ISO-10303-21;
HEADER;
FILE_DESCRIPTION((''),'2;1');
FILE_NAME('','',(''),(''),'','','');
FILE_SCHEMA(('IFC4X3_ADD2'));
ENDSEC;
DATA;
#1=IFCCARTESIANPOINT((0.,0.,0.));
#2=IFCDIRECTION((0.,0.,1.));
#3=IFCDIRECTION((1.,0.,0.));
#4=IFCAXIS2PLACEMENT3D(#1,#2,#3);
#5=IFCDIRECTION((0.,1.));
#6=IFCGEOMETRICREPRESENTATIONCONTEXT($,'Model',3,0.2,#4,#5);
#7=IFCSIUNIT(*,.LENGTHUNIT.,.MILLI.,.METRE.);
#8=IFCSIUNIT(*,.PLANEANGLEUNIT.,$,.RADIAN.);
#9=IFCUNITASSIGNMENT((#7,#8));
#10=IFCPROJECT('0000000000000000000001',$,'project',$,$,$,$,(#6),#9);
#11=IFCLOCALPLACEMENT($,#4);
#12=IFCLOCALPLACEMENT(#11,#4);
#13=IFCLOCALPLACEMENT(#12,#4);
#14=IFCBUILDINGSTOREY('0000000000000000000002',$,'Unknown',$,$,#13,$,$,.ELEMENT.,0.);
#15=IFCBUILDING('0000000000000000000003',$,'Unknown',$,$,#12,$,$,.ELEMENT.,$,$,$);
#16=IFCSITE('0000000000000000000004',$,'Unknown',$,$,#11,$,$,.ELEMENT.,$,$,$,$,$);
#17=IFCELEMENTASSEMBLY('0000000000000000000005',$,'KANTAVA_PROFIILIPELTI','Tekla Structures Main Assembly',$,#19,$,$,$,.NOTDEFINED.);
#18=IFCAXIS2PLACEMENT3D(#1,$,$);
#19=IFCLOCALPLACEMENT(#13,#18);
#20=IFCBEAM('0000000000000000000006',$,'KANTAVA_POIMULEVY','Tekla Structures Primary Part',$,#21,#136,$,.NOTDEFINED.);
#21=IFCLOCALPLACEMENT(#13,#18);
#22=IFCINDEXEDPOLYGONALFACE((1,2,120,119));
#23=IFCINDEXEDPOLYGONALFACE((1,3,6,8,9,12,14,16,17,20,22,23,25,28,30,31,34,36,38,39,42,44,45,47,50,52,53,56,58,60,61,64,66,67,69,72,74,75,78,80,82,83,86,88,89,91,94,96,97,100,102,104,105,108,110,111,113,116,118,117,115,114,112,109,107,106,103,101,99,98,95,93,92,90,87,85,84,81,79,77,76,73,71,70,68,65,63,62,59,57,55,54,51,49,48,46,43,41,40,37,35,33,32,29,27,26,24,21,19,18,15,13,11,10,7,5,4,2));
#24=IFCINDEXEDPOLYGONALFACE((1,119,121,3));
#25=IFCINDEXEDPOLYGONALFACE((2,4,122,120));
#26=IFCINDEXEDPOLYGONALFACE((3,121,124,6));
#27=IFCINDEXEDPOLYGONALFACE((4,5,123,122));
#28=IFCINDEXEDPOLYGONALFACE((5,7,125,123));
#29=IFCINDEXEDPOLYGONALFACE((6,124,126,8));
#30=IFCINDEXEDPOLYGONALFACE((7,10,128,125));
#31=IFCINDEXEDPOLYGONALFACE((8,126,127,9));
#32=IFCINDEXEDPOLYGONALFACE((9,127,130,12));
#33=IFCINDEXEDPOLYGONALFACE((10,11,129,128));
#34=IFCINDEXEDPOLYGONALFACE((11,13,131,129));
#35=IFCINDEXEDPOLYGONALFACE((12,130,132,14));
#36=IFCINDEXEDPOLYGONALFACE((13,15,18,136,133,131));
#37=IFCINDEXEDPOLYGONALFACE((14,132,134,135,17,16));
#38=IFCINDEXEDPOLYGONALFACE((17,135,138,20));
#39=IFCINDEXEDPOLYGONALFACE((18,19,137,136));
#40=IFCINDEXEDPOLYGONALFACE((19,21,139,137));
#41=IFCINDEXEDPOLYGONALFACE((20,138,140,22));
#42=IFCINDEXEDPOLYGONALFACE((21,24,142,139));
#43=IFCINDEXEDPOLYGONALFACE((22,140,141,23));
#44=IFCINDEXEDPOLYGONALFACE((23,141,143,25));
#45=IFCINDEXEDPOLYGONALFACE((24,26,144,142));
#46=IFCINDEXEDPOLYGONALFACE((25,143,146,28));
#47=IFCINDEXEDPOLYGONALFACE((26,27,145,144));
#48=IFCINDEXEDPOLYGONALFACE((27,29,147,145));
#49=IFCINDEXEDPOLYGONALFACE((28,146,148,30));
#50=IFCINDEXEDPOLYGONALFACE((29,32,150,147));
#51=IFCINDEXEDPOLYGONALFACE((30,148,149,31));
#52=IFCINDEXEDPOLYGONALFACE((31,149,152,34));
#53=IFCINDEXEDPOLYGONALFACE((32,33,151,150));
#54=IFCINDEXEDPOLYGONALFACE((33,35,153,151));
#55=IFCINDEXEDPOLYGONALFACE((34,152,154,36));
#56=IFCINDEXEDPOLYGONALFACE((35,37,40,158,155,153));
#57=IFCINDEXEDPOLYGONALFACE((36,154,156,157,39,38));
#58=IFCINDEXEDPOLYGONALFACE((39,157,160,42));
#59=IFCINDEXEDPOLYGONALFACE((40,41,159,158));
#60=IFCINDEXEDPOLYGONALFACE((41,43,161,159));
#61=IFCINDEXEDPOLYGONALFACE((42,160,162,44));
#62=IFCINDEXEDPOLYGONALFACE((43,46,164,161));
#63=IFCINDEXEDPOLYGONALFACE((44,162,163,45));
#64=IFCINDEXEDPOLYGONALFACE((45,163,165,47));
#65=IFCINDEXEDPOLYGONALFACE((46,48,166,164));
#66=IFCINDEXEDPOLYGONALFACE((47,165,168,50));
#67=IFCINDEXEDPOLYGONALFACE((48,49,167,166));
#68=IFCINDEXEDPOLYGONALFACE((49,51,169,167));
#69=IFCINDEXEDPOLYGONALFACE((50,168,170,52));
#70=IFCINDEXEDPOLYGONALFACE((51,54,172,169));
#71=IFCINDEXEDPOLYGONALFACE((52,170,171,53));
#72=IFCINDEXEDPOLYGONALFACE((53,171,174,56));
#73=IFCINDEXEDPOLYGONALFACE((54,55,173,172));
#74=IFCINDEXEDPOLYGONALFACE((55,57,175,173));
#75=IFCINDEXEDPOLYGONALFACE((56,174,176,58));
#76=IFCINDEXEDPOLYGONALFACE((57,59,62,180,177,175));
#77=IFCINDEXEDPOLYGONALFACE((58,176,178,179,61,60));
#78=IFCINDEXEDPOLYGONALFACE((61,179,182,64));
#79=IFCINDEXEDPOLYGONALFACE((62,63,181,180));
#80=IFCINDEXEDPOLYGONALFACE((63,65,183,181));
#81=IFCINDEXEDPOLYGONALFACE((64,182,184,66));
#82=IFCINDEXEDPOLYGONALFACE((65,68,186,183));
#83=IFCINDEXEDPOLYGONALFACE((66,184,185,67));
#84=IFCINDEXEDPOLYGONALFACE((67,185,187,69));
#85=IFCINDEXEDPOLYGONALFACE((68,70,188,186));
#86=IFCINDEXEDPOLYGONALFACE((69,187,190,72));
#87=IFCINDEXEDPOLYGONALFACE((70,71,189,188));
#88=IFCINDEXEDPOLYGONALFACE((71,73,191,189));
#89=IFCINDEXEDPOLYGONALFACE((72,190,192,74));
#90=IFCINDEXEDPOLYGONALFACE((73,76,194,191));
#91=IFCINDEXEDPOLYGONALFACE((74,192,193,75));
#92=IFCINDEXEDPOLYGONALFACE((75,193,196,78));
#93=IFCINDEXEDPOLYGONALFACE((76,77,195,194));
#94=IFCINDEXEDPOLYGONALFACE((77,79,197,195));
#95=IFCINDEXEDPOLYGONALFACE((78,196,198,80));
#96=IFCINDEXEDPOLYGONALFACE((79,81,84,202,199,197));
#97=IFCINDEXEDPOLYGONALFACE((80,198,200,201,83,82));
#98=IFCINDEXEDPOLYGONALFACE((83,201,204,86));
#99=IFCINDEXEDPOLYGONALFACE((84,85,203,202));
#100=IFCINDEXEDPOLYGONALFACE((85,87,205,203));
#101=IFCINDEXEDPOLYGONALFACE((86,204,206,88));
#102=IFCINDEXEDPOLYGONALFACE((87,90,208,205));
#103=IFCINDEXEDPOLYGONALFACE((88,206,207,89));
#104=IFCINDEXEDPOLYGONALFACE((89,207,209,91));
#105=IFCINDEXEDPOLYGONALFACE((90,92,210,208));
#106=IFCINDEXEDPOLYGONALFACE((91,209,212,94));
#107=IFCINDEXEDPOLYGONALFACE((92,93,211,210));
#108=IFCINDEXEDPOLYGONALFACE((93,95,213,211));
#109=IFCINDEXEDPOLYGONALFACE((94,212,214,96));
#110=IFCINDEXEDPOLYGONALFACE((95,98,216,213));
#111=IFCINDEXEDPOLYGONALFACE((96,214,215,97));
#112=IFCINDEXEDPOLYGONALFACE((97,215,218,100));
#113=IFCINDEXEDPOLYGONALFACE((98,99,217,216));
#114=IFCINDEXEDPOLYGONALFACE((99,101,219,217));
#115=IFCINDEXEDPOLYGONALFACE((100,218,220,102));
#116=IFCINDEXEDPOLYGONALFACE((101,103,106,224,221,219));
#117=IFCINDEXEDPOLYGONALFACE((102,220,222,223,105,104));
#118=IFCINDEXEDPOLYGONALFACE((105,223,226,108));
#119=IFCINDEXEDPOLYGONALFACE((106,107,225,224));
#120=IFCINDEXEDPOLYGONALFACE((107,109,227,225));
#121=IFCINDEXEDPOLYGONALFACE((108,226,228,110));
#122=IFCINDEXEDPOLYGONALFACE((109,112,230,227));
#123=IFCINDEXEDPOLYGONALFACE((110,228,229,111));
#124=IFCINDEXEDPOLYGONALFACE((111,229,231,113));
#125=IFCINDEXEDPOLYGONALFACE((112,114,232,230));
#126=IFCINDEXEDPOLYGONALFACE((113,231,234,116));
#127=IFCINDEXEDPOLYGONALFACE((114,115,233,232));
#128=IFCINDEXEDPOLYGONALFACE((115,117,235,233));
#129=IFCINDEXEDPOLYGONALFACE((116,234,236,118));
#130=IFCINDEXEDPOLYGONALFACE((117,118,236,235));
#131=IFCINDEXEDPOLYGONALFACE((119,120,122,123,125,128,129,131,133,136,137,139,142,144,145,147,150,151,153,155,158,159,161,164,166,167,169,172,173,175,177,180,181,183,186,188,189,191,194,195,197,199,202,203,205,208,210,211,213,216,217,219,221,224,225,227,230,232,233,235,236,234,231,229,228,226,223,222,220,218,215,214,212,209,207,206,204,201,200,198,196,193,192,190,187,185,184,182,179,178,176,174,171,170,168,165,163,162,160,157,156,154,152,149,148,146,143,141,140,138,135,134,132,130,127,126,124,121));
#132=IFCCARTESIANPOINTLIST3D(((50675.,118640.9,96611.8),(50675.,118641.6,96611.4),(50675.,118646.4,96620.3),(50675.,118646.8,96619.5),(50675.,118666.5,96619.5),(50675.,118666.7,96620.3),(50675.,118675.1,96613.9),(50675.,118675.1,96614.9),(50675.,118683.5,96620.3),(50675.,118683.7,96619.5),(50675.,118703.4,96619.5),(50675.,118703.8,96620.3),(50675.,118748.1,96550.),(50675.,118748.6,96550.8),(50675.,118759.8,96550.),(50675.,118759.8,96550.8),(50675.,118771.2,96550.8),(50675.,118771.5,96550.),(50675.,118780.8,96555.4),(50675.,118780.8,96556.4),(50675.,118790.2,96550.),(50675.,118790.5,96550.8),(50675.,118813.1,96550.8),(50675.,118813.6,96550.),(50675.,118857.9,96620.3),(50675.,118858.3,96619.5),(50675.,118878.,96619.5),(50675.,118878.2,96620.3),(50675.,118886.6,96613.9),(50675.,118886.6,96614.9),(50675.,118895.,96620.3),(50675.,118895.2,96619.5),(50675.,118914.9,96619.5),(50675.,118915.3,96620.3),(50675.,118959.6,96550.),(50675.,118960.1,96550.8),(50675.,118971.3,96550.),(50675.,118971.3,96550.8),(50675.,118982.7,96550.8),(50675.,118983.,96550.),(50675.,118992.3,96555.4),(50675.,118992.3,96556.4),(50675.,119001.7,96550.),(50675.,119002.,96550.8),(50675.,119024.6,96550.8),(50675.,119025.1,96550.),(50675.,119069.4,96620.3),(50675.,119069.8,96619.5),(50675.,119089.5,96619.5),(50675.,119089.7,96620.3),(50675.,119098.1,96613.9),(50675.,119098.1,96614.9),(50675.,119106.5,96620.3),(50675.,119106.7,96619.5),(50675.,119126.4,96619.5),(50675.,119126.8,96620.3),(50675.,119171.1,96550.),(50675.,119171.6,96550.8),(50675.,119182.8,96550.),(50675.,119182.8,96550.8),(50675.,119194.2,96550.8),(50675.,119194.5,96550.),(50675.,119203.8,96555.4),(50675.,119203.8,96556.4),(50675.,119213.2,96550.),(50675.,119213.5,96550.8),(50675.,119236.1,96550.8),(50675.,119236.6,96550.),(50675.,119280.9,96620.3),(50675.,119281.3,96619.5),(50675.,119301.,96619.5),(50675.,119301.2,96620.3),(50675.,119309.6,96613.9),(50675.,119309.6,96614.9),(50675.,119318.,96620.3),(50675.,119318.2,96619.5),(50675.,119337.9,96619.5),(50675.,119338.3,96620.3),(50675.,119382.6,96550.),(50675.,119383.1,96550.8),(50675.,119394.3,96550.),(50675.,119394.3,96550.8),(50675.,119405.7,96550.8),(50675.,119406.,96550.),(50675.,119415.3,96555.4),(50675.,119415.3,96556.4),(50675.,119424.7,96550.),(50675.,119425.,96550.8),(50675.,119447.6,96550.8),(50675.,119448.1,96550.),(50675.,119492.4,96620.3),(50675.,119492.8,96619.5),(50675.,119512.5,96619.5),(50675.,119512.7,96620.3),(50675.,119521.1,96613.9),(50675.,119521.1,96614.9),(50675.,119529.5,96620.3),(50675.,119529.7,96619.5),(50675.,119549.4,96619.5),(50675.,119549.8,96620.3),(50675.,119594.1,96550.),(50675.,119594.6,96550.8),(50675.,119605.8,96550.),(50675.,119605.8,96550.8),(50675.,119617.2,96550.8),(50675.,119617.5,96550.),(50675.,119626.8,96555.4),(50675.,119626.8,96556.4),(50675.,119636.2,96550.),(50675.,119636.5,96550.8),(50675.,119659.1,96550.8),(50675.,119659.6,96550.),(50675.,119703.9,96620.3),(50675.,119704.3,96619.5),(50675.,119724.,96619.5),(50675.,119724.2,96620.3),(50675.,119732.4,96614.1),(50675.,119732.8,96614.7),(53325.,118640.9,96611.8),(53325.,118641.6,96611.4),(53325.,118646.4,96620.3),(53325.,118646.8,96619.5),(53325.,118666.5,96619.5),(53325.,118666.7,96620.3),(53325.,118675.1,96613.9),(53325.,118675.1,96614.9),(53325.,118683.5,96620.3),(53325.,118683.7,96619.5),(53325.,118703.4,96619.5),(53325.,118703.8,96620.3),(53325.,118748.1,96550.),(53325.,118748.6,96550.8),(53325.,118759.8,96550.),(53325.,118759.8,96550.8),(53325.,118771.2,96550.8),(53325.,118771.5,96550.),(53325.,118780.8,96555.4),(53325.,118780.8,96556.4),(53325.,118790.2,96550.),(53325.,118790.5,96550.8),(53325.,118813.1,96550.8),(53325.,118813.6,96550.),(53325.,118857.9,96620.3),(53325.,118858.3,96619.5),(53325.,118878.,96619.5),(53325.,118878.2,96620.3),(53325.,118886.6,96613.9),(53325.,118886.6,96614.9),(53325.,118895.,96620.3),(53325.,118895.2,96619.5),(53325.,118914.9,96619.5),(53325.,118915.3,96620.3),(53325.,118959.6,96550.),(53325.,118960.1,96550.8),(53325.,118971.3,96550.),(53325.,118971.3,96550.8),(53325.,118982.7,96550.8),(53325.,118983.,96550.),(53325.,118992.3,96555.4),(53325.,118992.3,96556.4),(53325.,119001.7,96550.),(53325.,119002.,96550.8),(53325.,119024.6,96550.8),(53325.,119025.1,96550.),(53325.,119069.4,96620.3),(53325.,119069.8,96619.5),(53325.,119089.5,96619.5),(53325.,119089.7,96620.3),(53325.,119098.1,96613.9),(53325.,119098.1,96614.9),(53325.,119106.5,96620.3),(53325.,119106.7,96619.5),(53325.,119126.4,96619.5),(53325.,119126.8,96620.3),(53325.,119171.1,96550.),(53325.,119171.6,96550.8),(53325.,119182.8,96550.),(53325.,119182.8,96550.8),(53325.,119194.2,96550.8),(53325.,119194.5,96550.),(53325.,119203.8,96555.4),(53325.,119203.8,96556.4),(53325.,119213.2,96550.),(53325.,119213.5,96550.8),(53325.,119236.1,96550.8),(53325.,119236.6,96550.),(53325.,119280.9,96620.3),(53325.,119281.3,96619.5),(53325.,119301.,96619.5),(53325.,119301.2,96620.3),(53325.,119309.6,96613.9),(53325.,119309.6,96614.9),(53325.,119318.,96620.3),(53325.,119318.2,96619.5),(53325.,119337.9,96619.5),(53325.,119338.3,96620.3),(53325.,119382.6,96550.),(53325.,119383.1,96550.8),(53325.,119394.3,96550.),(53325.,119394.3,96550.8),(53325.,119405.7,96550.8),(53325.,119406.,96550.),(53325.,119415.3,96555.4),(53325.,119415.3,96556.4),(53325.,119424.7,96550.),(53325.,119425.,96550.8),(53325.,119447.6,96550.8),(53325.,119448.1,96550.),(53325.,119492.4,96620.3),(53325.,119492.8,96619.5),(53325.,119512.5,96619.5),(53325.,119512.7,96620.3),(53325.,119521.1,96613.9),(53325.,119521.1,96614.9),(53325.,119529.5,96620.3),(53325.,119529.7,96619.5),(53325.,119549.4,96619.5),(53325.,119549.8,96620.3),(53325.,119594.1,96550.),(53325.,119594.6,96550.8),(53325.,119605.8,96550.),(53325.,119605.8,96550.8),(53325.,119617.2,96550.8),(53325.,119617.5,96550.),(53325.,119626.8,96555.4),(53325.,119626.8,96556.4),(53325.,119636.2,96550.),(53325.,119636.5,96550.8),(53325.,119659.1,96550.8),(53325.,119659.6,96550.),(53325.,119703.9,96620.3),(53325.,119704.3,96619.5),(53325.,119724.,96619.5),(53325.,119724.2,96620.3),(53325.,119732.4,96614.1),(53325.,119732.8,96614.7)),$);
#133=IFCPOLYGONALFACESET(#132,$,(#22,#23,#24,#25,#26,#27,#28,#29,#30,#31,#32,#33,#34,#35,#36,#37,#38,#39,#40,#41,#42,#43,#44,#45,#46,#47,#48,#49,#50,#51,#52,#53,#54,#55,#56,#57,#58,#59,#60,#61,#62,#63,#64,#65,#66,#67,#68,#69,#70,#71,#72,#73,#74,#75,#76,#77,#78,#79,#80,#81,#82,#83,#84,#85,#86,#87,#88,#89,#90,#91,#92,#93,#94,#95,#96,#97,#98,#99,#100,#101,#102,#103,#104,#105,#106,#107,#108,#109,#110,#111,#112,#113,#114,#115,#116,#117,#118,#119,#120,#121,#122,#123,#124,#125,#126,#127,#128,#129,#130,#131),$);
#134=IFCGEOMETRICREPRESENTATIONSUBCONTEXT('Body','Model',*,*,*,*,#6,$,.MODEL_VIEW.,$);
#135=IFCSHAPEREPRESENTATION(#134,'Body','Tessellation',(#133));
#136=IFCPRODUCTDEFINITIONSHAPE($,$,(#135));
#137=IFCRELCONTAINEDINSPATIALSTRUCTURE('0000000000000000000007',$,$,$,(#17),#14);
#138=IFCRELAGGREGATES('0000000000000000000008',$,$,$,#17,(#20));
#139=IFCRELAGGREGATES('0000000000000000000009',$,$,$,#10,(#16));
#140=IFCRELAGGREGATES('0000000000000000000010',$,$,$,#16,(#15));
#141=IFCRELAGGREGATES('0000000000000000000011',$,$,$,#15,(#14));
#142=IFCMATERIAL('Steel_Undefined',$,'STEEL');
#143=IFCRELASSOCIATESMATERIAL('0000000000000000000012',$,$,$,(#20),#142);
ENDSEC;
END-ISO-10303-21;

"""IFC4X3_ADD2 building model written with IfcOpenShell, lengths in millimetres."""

from ifc_helpers import new_model, si_unit, direction, frame, origin_with_axes, place, context, subcontext, project, spatial, line, indexed_curve, outline, extrude, material, element, aggregate, save


model = new_model("IFC4X3_ADD2")

# Units and contexts
model_context = context("Model", 3, precision=0.2, world=origin_with_axes(), true_north=direction((0.0, 1.0)))
body_context = subcontext(model_context, "Body", "Model", "MODEL_VIEW")
ifc_project = project(units=[si_unit("LENGTHUNIT", "METRE", prefix="MILLI"), si_unit("PLANEANGLEUNIT", "RADIAN")], contexts=[model_context])

# Site, building, storey
site_placement = place(None, origin_with_axes())
site = spatial("IfcSite", under=ifc_project, at=site_placement, Name="Unknown", CompositionType="ELEMENT")
building_placement = place(site_placement, origin_with_axes())
building = spatial("IfcBuilding", under=site, at=building_placement, Name="Unknown", CompositionType="ELEMENT")
storey_placement = place(building_placement, origin_with_axes())
storey = spatial("IfcBuildingStorey", under=building, at=storey_placement, Name="Unknown", CompositionType="ELEMENT", Elevation=0.0)

# Element assembly, beam
assembly_1_placement = place(storey_placement, frame((53325.0, 119203.8, 96585.2), z_axis=(0.0, 1.0, 0.0), x_axis=(-1.0, 0.0, 0.0)))
assembly_1 = element("IfcElementAssembly", 1, at=assembly_1_placement, inside=storey, Name="KANTAVA_PROFIILIPELTI", Description="Tekla Structures Main Assembly", PredefinedType="NOTDEFINED")
ifc_material_1 = material(Name="Steel_Undefined", Category="STEEL")
beam_1_placement = place(assembly_1_placement, origin_with_axes())
beam_1 = element("IfcBeam", 2, at=beam_1_placement, material=ifc_material_1, Name="KANTAVA_POIMULEVY", Description="Tekla Structures Primary Part", PredefinedType="NOTDEFINED", context=body_context, shape_type="SolidModel", body=[
    extrude(outline(indexed_curve([(529.0, 29.6), (520.4, 35.1), (500.0, 35.1), (455.3, -34.4), (432.6, -34.4), (423.0, -28.8), (413.4, -34.4), (402.0, -34.4), (390.7, -34.4), (346.0, 35.1), (325.6, 35.1), (317.2, 29.7), (308.9, 35.1), (288.5, 35.1), (243.8, -34.4), (221.1, -34.4), (211.5, -28.8), (201.9, -34.4), (190.5, -34.4), (179.2, -34.4), (134.5, 35.1), (114.1, 35.1), (105.8, 29.7), (97.4, 35.1), (77.0, 35.1), (32.3, -34.4), (9.6, -34.4), (0.0, -28.8), (-9.6, -34.4), (-21.0, -34.4), (-32.3, -34.4), (-77.0, 35.1), (-97.4, 35.1), (-105.8, 29.7), (-114.1, 35.1), (-134.5, 35.1), (-179.2, -34.4), (-201.9, -34.4), (-211.5, -28.8), (-221.1, -34.4), (-232.5, -34.4), (-243.8, -34.4), (-288.5, 35.1), (-308.9, 35.1), (-317.2, 29.7), (-325.6, 35.1), (-346.0, 35.1), (-390.7, -34.4), (-413.4, -34.4), (-423.0, -28.8), (-432.6, -34.4), (-444.0, -34.4), (-455.3, -34.4), (-500.0, 35.1), (-520.4, 35.1), (-528.8, 29.7), (-537.1, 35.1), (-557.5, 35.1), (-562.9, 26.7), (-562.2, 26.2), (-557.0, 34.4), (-537.4, 34.4), (-528.8, 28.8), (-520.1, 34.4), (-500.5, 34.4), (-455.7, -35.1), (-444.0, -35.1), (-432.4, -35.1), (-423.0, -29.7), (-413.6, -35.1), (-390.3, -35.1), (-345.5, 34.4), (-325.9, 34.4), (-317.2, 28.8), (-308.6, 34.4), (-289.0, 34.4), (-244.2, -35.1), (-232.5, -35.1), (-220.9, -35.1), (-211.5, -29.7), (-202.1, -35.1), (-178.8, -35.1), (-134.0, 34.4), (-114.4, 34.4), (-105.8, 28.8), (-97.1, 34.4), (-77.5, 34.4), (-32.7, -35.1), (-21.0, -35.1), (-9.4, -35.1), (0.0, -29.7), (9.4, -35.1), (32.7, -35.1), (77.5, 34.4), (97.1, 34.4), (105.8, 28.8), (114.4, 34.4), (134.0, 34.4), (178.8, -35.1), (190.5, -35.1), (202.1, -35.1), (211.5, -29.7), (220.9, -35.1), (244.2, -35.1), (289.0, 34.4), (308.6, 34.4), (317.2, 28.8), (325.9, 34.4), (345.5, 34.4), (390.3, -35.1), (402.0, -35.1), (413.6, -35.1), (423.0, -29.7), (432.4, -35.1), (455.7, -35.1), (500.5, 34.4), (520.1, 34.4), (528.5, 28.9)], segments=[line(1, 2, 3, 4, 5, 6, 7, 8, 9, 10, 11, 12, 13, 14, 15, 16, 17, 18, 19, 20, 21, 22, 23, 24, 25, 26, 27, 28, 29, 30, 31, 32, 33, 34, 35, 36, 37, 38, 39, 40, 41, 42, 43, 44, 45, 46, 47, 48, 49, 50, 51, 52, 53, 54, 55, 56, 57, 58, 59, 60, 61, 62, 63, 64, 65, 66, 67, 68, 69, 70, 71, 72, 73, 74, 75, 76, 77, 78, 79, 80, 81, 82, 83, 84, 85, 86, 87, 88, 89, 90, 91, 92, 93, 94, 95, 96, 97, 98, 99, 100, 101, 102, 103, 104, 105, 106, 107, 108, 109, 110, 111, 112, 113, 114, 115, 116, 117, 118, 1)])), frame((0.0, 0.0, 0.0), z_axis=(-1.0, 0.0, 0.0), x_axis=(0.0, 0.0, 1.0)), (0.0, 0.0, -1.0), 2650.0),
])
aggregate(assembly_1, [beam_1])

save(model, "model.ifc")
